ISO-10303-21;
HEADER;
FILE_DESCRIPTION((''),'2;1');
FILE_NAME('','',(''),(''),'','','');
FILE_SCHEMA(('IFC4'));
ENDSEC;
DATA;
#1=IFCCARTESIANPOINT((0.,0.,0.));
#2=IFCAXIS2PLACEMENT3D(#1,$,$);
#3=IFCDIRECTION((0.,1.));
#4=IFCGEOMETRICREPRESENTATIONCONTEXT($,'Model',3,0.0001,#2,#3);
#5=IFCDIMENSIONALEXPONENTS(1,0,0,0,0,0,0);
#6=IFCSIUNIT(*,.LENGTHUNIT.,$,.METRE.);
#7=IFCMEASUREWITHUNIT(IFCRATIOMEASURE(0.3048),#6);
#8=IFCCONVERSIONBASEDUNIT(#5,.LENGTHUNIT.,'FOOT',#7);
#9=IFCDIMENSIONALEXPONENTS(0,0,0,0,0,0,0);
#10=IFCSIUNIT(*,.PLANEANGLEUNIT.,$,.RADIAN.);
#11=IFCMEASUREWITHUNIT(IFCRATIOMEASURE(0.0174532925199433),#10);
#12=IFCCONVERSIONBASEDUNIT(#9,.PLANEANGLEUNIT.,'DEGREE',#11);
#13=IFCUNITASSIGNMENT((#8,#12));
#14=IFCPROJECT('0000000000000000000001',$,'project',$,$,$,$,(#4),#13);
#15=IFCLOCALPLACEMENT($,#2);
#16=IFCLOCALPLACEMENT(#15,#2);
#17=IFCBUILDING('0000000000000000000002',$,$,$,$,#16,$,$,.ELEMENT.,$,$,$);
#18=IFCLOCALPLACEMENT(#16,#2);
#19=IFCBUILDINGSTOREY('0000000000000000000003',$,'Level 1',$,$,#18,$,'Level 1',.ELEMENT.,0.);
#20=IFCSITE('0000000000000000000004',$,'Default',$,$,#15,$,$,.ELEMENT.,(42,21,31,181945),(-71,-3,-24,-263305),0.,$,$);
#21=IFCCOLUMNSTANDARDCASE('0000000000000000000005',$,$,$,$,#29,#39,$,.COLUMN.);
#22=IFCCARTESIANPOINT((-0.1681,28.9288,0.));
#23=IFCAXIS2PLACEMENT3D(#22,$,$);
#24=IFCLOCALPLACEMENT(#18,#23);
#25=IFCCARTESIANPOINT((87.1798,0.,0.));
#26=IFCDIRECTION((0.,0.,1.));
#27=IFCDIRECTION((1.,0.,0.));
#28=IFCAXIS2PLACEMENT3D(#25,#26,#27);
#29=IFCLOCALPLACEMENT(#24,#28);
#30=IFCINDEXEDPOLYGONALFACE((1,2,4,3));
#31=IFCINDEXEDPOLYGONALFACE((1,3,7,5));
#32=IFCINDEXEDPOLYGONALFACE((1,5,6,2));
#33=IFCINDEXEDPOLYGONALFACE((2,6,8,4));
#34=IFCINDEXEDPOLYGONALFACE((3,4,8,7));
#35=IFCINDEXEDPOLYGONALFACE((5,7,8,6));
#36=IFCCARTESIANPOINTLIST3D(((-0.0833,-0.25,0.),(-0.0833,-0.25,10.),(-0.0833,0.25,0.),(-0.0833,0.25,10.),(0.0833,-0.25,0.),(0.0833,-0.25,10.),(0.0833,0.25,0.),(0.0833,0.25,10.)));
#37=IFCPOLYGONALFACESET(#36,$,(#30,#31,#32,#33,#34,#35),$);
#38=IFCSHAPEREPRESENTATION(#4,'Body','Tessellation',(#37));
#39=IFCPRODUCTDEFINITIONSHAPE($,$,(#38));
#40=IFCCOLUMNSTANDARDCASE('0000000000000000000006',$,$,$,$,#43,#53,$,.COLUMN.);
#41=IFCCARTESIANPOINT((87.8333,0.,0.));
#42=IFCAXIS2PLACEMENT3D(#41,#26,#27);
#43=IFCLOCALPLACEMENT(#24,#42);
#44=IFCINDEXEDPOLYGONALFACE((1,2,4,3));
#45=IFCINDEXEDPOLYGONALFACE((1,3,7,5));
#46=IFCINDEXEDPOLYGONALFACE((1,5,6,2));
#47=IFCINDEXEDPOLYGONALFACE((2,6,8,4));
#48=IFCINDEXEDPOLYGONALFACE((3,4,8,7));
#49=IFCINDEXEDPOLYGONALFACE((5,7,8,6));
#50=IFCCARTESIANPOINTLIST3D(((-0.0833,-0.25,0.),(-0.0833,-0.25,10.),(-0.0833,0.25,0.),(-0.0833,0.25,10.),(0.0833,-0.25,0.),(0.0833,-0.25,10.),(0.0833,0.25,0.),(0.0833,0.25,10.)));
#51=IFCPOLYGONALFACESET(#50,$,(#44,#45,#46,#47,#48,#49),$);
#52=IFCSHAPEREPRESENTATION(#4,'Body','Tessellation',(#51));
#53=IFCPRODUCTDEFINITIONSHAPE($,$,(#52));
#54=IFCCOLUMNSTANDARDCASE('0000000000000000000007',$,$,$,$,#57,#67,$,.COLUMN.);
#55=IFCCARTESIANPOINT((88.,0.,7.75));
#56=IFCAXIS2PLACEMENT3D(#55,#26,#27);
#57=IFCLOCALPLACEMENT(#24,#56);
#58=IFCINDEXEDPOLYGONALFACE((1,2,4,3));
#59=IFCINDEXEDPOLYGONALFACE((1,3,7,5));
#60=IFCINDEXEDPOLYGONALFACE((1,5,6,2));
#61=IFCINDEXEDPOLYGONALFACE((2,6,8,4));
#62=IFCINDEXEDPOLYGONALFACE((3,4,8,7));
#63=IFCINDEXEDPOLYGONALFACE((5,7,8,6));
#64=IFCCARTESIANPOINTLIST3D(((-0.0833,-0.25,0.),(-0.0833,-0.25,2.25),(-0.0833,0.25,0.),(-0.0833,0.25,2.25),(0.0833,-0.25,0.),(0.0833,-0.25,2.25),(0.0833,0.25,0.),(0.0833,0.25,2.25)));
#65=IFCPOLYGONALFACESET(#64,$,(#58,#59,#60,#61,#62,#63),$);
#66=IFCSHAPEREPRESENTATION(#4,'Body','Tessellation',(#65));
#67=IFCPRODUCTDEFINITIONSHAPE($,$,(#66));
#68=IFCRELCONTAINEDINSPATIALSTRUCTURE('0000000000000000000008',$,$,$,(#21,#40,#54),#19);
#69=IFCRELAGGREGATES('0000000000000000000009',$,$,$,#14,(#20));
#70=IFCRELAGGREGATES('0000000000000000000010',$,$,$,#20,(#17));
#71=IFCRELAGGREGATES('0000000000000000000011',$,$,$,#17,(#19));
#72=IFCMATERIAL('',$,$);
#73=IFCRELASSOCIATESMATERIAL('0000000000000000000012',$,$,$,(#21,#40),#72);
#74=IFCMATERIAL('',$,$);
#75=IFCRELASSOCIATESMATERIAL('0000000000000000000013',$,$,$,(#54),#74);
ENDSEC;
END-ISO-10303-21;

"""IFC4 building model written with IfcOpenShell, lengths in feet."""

from ifc_helpers import new_model, entity, si_unit, converted_unit, direction, frame, origin, place, context, project, spatial, rectangle, extrude, material, element, save


model = new_model("IFC4")

# Units and contexts
model_context = context("Model", 3, precision=0.0001, world=origin(), true_north=direction((0.0, 1.0)))
ifc_project = project(units=[converted_unit("LENGTHUNIT", "FOOT", entity("IfcRatioMeasure", 0.3048), si_unit("LENGTHUNIT", "METRE"), dimensions=[1, 0, 0, 0, 0, 0, 0]), converted_unit("PLANEANGLEUNIT", "DEGREE", entity("IfcRatioMeasure", 0.0174532925199433), si_unit("PLANEANGLEUNIT", "RADIAN"), dimensions=[0, 0, 0, 0, 0, 0, 0])], contexts=[model_context])

# Site, building, storey
site_placement = place(None, origin())
site = spatial("IfcSite", under=ifc_project, at=site_placement, Name="Default", CompositionType="ELEMENT", RefLatitude=(42, 21, 31, 181945), RefLongitude=(-71, -3, -24, -263305), RefElevation=0.0)
building_placement = place(site_placement, origin())
building = spatial("IfcBuilding", under=site, at=building_placement, CompositionType="ELEMENT")
storey_placement = place(building_placement, origin())
storey = spatial("IfcBuildingStorey", under=building, at=storey_placement, Name="Level 1", LongName="Level 1", CompositionType="ELEMENT", Elevation=0.0)

# Columns
ifc_material_1 = material(Name="")
placement = place(storey_placement, frame((-0.1681, 28.9288, 0.0)))
for number, where, z_axis, x_axis in (
    (1, (87.1798, 0.0, 0.0), (0.0, 0.0, 1.0), (1.0, 0.0, 0.0)),
    (2, (87.8333, 0.0, 0.0), (0.0, 0.0, 1.0), (1.0, 0.0, 0.0)),
):
    element("IfcColumnStandardCase", number, at=place(placement, frame(where, z_axis=z_axis, x_axis=x_axis)), inside=storey, material=ifc_material_1, PredefinedType="COLUMN", context=model_context, shape_type="SweptSolid", body=[
        extrude(rectangle(XDim=0.1667, YDim=0.5), origin(), (0.0, 0.0, 1.0), 10.0),
    ])
ifc_material_2 = material(Name="")
for number, where, z_axis, x_axis in (
    (3, (88.0, 0.0, 7.75), (0.0, 0.0, 1.0), (1.0, 0.0, 0.0)),
):
    element("IfcColumnStandardCase", number, at=place(placement, frame(where, z_axis=z_axis, x_axis=x_axis)), inside=storey, material=ifc_material_2, PredefinedType="COLUMN", context=model_context, shape_type="SweptSolid", body=[
        extrude(rectangle(XDim=0.1667, YDim=0.5), origin(), (0.0, 0.0, 1.0), 2.25),
    ])

save(model, "model.ifc")
